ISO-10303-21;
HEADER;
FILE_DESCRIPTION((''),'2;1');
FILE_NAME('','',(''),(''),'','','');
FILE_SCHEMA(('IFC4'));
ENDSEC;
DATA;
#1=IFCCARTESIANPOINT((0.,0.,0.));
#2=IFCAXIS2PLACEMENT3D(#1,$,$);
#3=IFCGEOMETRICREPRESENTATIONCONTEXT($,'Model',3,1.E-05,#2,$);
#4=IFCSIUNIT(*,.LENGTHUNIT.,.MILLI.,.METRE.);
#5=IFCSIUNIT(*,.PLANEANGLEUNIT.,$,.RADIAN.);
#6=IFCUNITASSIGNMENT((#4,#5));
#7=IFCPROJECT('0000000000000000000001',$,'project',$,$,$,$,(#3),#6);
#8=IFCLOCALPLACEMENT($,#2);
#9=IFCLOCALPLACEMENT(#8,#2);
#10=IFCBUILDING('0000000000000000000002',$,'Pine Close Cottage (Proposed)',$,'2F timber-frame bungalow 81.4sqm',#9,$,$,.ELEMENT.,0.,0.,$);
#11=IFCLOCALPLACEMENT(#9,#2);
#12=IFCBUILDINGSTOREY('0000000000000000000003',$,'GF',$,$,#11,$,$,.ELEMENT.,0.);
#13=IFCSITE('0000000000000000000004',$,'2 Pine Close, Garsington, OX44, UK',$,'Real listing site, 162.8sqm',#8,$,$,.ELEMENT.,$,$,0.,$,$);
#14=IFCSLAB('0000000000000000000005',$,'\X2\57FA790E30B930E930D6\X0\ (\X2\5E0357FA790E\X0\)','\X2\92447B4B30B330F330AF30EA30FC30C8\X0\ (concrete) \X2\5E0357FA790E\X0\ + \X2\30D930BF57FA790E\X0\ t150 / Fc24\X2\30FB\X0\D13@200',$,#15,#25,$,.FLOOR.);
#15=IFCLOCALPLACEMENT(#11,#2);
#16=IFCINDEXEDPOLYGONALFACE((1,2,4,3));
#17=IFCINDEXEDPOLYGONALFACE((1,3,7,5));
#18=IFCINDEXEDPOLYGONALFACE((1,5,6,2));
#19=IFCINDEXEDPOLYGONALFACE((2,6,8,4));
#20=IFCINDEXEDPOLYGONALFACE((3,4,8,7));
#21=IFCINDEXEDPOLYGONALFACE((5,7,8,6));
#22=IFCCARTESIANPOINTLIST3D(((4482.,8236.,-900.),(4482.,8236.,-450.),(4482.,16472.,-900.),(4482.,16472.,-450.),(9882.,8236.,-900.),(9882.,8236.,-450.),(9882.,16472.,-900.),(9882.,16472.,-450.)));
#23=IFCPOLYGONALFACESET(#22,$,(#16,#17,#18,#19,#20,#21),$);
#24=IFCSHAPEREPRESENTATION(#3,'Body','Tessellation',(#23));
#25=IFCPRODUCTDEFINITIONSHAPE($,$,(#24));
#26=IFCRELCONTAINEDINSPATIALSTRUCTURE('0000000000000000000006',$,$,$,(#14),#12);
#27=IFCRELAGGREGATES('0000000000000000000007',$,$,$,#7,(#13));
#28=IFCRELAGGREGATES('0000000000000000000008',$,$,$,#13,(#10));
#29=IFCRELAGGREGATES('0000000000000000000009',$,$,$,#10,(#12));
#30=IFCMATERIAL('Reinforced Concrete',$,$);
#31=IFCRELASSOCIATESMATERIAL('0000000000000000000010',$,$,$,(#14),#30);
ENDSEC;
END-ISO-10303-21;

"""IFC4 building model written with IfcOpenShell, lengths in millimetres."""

from ifc_helpers import new_model, si_unit, frame, frame_2d, origin, place, context, project, spatial, rectangle, extrude, material, element, save


model = new_model("IFC4")

# Units and contexts
model_context = context("Model", 3, precision=1e-05, world=origin())
ifc_project = project(units=[si_unit("LENGTHUNIT", "METRE", prefix="MILLI"), si_unit("PLANEANGLEUNIT", "RADIAN")], contexts=[model_context])

# Site, building, storey
site_placement = place(None, origin())
site = spatial("IfcSite", under=ifc_project, at=site_placement, Name="2 Pine Close, Garsington, OX44, UK", ObjectType="Real listing site, 162.8sqm", CompositionType="ELEMENT", RefElevation=0.0)
building_placement = place(site_placement, origin())
building = spatial("IfcBuilding", under=site, at=building_placement, Name="Pine Close Cottage (Proposed)", ObjectType="2F timber-frame bungalow 81.4sqm", CompositionType="ELEMENT", ElevationOfRefHeight=0.0, ElevationOfTerrain=0.0)
storey_placement = place(building_placement, origin())
storey = spatial("IfcBuildingStorey", under=building, at=storey_placement, Name="GF", CompositionType="ELEMENT", Elevation=0.0)

# Slab
ifc_material_1 = material(Name="Reinforced Concrete")
slab_1_placement = place(storey_placement, frame((2241.0, 4118.0, -450.0)))
element("IfcSlab", 1, at=slab_1_placement, inside=storey, material=ifc_material_1, Name="基礎スラブ (布基礎)", Description="鉄筋コンクリート (concrete) 布基礎 + ベタ基礎 t150 / Fc24・D13@200", PredefinedType="FLOOR", context=model_context, shape_type="SweptSolid", body=[
    extrude(rectangle(XDim=5400.0, YDim=8236.0, at=frame_2d((2700.0, 4118.0))), frame((2241.0, 4118.0, -450.0)), (0.0, 0.0, 1.0), 450.0),
])

save(model, "model.ifc")
